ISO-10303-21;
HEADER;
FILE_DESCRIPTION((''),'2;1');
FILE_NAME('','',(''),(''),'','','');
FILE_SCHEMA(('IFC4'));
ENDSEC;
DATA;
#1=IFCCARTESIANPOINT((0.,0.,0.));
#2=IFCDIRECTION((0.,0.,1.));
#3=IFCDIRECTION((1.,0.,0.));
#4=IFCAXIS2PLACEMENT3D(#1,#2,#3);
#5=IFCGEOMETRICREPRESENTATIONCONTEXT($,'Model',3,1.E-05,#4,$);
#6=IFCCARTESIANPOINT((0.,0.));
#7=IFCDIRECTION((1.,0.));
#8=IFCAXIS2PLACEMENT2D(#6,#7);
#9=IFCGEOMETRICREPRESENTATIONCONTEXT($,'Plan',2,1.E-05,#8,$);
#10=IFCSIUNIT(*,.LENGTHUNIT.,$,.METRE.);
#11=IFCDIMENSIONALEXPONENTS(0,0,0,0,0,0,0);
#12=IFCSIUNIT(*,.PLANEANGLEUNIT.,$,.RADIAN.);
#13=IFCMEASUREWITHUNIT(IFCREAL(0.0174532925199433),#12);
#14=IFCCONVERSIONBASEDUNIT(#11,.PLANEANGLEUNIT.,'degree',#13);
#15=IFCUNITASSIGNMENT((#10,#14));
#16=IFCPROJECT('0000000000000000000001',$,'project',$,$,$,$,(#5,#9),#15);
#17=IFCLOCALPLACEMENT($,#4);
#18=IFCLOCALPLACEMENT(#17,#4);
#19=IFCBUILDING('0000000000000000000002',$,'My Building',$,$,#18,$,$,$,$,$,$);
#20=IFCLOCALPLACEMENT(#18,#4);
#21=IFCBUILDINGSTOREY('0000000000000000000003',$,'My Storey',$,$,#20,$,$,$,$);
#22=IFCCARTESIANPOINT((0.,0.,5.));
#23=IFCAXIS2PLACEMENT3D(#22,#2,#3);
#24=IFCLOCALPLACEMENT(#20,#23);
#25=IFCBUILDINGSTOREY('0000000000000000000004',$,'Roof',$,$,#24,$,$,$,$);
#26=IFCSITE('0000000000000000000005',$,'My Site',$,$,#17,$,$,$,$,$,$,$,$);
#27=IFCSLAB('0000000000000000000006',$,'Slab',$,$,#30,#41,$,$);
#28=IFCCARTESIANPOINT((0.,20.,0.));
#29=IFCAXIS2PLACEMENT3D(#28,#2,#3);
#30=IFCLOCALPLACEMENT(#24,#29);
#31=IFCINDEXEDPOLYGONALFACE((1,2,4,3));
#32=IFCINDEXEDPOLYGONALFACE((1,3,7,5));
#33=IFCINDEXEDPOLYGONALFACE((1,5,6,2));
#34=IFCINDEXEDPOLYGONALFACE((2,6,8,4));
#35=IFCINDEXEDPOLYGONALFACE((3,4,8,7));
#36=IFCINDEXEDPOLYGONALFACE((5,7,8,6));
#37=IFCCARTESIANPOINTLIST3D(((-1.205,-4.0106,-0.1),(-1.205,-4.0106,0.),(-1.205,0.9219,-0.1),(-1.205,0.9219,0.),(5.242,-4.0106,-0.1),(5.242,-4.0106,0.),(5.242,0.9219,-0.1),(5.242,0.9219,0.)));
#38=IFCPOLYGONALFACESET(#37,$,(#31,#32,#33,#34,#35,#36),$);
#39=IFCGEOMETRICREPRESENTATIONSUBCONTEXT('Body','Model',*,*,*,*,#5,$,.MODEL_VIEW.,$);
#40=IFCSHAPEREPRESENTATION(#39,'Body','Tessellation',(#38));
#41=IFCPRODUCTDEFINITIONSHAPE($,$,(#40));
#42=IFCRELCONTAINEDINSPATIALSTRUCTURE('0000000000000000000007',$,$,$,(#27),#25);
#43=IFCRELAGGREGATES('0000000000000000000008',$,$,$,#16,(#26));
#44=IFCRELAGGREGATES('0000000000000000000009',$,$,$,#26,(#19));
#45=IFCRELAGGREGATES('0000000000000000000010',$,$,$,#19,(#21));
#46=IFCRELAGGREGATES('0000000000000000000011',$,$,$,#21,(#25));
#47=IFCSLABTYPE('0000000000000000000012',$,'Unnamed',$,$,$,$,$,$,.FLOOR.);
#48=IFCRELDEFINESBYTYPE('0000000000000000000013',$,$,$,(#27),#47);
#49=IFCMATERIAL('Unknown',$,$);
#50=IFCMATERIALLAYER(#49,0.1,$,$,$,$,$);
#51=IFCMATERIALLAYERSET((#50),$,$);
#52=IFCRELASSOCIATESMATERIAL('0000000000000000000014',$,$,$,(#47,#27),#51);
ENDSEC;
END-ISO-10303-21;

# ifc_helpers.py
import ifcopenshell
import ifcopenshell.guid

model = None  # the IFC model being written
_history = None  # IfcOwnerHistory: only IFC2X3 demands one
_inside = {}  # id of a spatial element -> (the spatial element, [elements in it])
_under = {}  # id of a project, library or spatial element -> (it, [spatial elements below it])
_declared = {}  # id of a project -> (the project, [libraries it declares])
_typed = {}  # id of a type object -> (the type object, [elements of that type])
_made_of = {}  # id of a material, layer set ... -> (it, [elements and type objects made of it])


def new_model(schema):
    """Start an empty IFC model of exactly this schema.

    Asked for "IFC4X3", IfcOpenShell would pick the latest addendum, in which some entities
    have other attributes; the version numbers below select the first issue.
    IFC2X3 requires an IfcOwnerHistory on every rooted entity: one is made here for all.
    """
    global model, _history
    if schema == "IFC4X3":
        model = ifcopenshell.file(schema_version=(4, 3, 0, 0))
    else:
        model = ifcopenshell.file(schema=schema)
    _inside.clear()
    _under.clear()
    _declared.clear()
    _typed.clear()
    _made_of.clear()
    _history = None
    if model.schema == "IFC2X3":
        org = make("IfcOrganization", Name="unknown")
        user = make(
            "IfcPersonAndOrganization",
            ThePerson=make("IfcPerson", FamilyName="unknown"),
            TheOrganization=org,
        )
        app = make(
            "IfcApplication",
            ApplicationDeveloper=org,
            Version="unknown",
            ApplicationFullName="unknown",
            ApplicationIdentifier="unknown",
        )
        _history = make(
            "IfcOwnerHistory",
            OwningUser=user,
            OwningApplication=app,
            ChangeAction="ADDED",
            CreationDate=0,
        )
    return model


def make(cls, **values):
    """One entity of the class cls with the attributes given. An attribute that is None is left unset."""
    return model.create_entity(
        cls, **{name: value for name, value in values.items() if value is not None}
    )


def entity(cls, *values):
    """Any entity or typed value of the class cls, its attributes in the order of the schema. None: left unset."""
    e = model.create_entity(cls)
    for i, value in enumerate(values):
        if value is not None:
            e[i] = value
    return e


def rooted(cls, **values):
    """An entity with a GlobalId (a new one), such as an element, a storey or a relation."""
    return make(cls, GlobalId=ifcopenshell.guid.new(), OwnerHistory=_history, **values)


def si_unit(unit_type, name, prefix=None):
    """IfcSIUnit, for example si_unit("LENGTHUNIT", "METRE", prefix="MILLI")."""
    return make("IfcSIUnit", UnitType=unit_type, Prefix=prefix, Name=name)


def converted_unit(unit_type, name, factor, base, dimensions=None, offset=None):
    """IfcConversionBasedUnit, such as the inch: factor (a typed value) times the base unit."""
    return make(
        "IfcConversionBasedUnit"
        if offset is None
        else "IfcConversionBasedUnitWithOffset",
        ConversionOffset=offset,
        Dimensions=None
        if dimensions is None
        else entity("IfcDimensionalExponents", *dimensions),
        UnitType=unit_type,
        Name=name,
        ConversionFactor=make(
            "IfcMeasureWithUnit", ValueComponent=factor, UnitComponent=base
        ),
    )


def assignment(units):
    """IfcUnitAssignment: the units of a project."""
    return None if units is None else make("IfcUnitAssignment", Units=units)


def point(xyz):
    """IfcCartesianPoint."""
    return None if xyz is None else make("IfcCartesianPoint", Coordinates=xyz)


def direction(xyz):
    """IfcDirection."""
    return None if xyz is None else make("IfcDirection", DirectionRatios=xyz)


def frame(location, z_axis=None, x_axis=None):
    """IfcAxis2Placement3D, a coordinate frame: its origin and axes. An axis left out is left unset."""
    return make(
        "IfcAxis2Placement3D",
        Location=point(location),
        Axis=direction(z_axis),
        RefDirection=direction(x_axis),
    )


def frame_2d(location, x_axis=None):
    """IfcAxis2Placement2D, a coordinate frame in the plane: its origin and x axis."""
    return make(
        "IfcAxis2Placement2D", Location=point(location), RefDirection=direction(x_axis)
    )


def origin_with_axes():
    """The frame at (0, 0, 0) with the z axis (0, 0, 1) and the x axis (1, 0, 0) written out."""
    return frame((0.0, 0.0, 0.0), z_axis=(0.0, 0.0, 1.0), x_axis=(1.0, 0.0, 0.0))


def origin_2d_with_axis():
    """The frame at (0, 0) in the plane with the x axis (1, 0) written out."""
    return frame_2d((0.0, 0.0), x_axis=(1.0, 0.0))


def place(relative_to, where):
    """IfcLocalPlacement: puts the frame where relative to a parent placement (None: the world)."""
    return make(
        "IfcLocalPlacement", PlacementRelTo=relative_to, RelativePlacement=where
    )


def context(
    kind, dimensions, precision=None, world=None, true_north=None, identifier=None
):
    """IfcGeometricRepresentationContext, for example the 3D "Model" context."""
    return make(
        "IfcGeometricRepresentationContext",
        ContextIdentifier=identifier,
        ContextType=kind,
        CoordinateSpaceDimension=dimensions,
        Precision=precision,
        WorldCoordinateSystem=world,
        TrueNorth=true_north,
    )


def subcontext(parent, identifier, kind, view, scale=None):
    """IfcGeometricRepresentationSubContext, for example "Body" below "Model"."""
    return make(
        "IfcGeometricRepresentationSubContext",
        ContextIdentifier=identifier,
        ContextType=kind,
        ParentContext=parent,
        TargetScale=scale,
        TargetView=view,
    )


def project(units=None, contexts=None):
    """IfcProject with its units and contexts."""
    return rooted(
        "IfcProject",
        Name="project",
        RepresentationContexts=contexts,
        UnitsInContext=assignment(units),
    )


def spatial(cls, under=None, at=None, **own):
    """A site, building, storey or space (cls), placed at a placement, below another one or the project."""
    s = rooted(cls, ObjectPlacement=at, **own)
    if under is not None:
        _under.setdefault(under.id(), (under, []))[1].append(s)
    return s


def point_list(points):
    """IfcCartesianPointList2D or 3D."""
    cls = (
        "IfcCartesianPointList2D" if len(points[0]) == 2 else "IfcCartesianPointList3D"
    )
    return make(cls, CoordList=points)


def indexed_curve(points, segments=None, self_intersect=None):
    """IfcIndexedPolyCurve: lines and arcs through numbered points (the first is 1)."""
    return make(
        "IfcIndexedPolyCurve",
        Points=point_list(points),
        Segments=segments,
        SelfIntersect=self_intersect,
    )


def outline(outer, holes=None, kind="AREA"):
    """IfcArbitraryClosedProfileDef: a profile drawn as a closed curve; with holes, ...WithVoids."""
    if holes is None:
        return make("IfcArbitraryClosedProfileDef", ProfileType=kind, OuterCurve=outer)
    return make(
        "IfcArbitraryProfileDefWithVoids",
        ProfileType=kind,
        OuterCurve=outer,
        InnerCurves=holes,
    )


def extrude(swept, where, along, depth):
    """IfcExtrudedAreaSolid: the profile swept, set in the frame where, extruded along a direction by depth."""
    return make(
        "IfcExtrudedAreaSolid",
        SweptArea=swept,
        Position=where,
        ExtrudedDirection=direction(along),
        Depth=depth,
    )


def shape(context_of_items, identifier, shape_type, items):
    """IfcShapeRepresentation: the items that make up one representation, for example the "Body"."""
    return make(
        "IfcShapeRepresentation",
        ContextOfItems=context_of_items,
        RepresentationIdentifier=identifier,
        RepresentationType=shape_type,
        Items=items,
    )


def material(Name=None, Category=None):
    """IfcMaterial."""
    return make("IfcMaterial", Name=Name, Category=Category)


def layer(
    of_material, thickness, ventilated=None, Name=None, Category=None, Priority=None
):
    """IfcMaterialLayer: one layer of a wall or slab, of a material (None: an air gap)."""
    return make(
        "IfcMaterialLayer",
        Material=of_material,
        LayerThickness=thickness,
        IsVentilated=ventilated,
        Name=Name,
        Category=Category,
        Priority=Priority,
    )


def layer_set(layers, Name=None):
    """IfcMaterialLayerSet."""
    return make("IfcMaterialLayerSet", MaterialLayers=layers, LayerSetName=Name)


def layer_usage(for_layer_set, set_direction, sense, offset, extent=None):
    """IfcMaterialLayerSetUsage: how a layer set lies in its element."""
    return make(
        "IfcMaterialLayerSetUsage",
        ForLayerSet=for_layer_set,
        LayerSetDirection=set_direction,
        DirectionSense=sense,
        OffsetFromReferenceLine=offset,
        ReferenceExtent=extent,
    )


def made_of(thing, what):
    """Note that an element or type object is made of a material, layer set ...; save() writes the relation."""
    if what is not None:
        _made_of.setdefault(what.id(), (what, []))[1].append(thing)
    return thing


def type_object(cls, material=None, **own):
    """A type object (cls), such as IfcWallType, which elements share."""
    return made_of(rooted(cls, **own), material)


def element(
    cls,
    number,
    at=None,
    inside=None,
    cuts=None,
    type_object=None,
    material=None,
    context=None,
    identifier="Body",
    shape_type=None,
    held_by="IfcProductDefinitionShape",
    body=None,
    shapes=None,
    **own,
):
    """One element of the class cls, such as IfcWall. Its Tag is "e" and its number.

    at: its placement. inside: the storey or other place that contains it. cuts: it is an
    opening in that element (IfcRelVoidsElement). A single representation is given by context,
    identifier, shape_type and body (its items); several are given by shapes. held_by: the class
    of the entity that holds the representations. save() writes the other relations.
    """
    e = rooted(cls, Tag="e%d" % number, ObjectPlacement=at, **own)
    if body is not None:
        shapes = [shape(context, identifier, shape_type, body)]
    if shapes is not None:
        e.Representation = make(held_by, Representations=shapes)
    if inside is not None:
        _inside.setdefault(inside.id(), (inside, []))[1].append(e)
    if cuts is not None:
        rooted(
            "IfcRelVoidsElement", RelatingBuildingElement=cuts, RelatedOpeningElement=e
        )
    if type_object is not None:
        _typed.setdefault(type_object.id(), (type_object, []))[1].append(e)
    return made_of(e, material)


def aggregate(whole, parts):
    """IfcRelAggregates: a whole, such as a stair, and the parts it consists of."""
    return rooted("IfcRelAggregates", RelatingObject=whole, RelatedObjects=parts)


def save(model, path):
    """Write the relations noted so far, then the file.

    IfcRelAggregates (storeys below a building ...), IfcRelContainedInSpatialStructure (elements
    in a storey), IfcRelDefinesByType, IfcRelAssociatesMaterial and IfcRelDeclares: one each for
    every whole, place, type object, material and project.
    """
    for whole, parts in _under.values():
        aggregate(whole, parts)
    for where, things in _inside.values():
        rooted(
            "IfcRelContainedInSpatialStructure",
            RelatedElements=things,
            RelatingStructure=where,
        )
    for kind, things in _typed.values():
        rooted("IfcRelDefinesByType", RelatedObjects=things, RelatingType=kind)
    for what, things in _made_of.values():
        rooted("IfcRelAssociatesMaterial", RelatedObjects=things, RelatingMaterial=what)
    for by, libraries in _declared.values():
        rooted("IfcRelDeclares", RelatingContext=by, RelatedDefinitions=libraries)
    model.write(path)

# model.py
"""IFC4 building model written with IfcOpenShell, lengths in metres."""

from ifc_helpers import new_model, entity, si_unit, converted_unit, frame, origin_with_axes, origin_2d_with_axis, place, context, subcontext, project, spatial, indexed_curve, outline, extrude, material, layer, layer_set, layer_usage, type_object, element, save


model = new_model("IFC4")

# Units and contexts
model_context = context("Model", 3, precision=1e-05, world=origin_with_axes())
plan_context = context("Plan", 2, precision=1e-05, world=origin_2d_with_axis())
body_context = subcontext(model_context, "Body", "Model", "MODEL_VIEW")
ifc_project = project(units=[si_unit("LENGTHUNIT", "METRE"), converted_unit("PLANEANGLEUNIT", "degree", entity("IfcReal", 0.0174532925199433), si_unit("PLANEANGLEUNIT", "RADIAN"), dimensions=[0, 0, 0, 0, 0, 0, 0])], contexts=[model_context, plan_context])

# Site, building, storeys
site_placement = place(None, origin_with_axes())
site = spatial("IfcSite", under=ifc_project, at=site_placement, Name="My Site")
building_placement = place(site_placement, origin_with_axes())
building = spatial("IfcBuilding", under=site, at=building_placement, Name="My Building")
storey_1_placement = place(building_placement, origin_with_axes())
storey_1 = spatial("IfcBuildingStorey", under=building, at=storey_1_placement, Name="My Storey")
storey_2_placement = place(storey_1_placement, frame((0.0, 0.0, 5.0), z_axis=(0.0, 0.0, 1.0), x_axis=(1.0, 0.0, 0.0)))
storey_2 = spatial("IfcBuildingStorey", under=storey_1, at=storey_2_placement, Name="Roof")

# Slab
ifc_material = material(Name="Unknown")
ifc_layer = layer(ifc_material, 0.1)
ifc_layer_set = layer_set([ifc_layer])
ifc_layer_usage = layer_usage(ifc_layer_set, "AXIS3", "POSITIVE", -0.1)
slab_type = type_object("IfcSlabType", Name="Unnamed", PredefinedType="FLOOR", material=ifc_layer_set)
slab_placement = place(storey_2_placement, frame((0.0, 20.0, 0.0), z_axis=(0.0, 0.0, 1.0), x_axis=(1.0, 0.0, 0.0)))
element("IfcSlab", 1, at=slab_placement, inside=storey_2, type_object=slab_type, material=ifc_layer_usage, Name="Slab", context=body_context, shape_type="SweptSolid", body=[
    extrude(outline(indexed_curve([(5.242, 0.9219), (5.242, -4.0106), (-1.205, -4.0106), (-1.205, 0.9219), (5.242, 0.9219)])), frame((0.0, 0.0, -0.1), z_axis=(0.0, 0.0, 1.0), x_axis=(1.0, 0.0, 0.0)), (0.0, 0.0, 1.0), 0.1),
])

save(model, "model.ifc")
